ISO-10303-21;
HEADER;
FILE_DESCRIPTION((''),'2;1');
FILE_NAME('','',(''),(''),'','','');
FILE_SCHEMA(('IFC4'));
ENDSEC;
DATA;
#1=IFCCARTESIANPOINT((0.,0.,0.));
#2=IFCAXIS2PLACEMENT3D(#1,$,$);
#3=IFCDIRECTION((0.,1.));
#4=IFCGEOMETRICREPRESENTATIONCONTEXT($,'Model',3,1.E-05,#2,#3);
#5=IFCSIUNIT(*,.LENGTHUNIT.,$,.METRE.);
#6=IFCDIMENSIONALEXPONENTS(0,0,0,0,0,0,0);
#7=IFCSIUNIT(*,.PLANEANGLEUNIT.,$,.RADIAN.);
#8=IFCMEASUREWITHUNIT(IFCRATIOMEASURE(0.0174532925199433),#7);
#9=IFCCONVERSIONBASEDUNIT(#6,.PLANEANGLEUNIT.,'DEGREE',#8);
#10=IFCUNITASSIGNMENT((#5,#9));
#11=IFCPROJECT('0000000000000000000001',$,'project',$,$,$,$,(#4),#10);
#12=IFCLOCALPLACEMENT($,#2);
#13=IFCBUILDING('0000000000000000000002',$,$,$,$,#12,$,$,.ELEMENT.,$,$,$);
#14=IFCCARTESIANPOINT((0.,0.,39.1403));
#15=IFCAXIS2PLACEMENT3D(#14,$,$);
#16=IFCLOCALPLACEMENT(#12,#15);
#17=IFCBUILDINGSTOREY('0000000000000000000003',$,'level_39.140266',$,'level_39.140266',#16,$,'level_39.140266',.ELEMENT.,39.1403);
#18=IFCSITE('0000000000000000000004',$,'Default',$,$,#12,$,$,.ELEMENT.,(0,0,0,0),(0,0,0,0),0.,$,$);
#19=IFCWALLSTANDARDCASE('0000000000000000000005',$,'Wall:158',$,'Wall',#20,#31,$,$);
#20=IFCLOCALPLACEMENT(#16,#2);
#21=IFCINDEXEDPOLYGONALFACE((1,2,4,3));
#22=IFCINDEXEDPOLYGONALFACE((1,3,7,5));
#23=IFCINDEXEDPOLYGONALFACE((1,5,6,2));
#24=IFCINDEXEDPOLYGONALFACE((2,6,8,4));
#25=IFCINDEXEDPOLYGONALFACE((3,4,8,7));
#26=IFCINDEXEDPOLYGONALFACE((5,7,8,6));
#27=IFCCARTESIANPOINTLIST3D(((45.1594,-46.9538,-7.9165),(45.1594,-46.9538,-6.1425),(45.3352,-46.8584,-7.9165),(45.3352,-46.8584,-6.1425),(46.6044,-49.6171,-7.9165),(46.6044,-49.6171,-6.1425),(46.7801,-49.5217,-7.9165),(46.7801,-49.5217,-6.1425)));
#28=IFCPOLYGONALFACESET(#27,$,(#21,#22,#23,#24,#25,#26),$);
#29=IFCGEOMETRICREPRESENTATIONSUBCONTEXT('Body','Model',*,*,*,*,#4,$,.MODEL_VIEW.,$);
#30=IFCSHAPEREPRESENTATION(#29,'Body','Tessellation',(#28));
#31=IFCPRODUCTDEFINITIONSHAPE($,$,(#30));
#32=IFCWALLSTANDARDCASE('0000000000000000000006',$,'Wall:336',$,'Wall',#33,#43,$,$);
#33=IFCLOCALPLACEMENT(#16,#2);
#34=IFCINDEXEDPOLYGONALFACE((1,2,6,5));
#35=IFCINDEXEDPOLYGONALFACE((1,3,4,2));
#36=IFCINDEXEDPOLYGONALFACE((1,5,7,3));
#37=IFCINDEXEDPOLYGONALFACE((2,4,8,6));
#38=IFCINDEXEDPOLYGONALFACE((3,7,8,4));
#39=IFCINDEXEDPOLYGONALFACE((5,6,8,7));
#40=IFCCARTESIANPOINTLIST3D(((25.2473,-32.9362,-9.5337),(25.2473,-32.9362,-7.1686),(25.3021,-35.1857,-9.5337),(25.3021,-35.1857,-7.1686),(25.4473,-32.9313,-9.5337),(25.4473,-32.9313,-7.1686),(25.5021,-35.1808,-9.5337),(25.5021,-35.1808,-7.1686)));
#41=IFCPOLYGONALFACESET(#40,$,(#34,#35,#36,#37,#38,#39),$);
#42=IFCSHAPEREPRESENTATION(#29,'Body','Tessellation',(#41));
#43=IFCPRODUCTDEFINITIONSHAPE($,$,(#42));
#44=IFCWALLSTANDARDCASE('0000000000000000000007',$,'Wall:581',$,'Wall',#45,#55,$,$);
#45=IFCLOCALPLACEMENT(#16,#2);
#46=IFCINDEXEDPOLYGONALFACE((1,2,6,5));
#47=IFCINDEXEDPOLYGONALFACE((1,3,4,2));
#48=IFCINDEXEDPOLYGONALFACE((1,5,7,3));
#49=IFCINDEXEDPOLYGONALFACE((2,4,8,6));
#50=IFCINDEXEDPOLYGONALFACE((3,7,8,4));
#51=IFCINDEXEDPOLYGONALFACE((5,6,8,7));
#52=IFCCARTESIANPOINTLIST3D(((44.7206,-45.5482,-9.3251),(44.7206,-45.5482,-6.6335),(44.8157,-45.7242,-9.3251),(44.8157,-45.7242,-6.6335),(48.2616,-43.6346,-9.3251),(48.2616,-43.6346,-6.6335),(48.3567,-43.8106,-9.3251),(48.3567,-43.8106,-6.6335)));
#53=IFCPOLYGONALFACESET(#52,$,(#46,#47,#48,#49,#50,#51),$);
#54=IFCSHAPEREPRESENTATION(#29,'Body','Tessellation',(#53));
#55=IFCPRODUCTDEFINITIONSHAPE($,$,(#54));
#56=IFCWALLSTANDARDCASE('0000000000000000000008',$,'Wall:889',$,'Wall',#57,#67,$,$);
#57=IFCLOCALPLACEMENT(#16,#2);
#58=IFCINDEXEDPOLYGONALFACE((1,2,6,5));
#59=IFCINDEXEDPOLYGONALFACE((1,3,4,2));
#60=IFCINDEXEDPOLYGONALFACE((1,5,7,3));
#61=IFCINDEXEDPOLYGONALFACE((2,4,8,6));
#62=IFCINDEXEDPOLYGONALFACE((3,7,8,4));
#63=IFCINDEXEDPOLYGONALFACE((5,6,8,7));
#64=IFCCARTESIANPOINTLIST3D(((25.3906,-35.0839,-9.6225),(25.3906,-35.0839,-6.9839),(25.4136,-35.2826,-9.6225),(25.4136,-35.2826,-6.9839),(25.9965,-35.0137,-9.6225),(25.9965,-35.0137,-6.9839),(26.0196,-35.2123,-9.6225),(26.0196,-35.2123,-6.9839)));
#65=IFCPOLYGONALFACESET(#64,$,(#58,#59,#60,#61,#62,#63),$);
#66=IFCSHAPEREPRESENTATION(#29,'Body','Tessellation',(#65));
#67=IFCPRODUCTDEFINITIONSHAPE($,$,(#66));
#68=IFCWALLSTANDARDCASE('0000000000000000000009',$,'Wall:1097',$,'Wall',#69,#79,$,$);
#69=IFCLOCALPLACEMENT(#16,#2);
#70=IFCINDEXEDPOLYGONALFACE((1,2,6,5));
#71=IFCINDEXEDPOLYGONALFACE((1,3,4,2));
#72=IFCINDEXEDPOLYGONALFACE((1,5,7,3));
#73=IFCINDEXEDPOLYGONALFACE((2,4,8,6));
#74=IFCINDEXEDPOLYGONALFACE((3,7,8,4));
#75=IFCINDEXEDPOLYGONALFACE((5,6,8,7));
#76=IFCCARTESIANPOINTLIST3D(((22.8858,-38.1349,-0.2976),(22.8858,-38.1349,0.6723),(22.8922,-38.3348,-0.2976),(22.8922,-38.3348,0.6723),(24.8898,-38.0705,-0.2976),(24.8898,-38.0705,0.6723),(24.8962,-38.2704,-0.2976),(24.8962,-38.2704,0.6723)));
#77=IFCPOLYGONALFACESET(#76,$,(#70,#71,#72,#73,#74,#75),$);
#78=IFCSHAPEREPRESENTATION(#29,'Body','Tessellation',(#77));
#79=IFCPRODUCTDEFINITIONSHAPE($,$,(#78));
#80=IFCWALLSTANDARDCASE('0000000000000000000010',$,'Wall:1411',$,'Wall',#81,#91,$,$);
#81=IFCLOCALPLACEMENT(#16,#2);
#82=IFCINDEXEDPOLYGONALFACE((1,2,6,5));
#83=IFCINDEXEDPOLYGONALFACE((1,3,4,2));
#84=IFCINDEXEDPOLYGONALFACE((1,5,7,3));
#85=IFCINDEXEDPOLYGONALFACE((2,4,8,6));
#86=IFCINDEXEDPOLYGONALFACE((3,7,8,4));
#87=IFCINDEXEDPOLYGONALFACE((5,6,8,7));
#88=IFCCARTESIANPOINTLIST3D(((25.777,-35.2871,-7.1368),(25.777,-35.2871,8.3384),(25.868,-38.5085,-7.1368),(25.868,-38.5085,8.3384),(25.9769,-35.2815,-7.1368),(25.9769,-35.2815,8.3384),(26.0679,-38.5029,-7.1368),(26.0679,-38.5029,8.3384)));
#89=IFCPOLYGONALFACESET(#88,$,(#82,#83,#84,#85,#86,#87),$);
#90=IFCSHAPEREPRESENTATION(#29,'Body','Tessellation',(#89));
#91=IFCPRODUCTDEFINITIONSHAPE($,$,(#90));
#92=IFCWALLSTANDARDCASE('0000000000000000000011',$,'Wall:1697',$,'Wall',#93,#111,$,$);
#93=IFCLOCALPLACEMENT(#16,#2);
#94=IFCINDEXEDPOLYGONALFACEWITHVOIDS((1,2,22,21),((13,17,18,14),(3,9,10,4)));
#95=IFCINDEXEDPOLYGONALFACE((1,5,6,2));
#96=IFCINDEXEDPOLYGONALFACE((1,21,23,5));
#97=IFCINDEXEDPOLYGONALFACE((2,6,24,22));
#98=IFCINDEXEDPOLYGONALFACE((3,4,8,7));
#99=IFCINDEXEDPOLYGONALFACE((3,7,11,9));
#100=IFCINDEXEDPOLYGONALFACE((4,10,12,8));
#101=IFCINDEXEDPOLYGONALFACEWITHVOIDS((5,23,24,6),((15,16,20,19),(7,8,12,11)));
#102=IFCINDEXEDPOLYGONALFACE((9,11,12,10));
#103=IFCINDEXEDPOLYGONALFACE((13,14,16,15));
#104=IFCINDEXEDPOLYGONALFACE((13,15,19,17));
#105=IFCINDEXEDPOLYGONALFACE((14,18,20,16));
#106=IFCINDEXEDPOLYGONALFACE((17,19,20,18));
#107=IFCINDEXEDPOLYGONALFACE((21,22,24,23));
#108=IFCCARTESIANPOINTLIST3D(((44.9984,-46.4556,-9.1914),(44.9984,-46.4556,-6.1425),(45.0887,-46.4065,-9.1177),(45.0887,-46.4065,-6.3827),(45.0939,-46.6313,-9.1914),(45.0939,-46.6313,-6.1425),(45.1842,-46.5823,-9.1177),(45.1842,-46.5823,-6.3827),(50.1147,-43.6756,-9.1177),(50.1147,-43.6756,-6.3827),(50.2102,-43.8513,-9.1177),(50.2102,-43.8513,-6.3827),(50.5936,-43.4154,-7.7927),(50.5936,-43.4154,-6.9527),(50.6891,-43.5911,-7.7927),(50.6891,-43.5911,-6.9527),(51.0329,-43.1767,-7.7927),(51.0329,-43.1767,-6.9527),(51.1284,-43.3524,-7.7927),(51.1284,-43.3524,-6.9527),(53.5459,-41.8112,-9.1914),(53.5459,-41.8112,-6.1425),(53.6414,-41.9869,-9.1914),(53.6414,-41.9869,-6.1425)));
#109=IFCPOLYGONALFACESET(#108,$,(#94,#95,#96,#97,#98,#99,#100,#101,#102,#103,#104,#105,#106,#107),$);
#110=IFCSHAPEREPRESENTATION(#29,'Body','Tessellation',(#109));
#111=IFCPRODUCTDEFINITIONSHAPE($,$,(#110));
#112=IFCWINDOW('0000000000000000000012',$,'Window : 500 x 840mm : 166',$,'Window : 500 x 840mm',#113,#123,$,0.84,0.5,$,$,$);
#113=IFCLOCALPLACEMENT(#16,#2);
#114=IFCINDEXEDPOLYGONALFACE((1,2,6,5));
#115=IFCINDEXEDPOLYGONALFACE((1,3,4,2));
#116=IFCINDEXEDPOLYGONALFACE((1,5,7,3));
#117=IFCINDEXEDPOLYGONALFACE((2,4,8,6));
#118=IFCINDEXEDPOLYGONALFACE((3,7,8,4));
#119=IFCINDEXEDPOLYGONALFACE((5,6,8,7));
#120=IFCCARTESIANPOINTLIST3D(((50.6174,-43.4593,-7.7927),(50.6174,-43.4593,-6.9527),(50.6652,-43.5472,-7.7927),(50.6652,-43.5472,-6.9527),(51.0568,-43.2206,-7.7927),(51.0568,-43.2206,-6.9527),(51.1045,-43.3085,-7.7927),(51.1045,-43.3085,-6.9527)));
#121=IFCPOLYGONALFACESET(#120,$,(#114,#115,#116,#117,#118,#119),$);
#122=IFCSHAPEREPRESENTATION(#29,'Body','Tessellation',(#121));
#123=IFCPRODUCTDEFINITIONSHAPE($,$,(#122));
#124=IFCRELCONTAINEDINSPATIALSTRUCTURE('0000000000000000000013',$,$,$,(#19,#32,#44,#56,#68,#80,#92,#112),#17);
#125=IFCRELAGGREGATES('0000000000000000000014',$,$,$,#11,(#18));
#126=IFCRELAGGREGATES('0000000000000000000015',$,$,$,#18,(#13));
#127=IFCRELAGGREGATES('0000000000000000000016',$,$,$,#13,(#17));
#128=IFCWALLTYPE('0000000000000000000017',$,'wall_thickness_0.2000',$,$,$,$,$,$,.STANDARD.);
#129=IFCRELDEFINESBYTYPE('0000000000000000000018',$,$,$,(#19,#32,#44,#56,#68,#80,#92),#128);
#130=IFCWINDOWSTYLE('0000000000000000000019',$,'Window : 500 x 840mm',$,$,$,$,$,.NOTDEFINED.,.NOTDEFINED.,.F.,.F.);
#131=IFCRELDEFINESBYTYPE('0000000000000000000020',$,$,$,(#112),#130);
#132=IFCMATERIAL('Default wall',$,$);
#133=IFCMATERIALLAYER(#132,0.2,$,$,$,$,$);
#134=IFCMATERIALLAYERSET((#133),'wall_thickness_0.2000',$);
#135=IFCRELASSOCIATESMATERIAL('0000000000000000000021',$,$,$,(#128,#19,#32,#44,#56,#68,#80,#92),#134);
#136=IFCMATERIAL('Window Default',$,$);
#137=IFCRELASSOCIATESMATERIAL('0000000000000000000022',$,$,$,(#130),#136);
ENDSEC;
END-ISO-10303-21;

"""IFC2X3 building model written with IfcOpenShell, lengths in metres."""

from ifc_helpers import new_model, entity, si_unit, converted_unit, direction, frame, frame_2d, origin, origin_2d_with_axis, place, context, subcontext, project, spatial, polyline, rectangle, outline, extrude, source, transform, mapped, material, layer, layer_set, layer_usage, type_object, type_shapes, element, fill, save


model = new_model("IFC2X3")

# Units and contexts
model_context = context("Model", 3, precision=1e-05, world=origin(), true_north=direction((0.0, 1.0)))
body_context = subcontext(model_context, "Body", "Model", "MODEL_VIEW")
ifc_project = project(units=[si_unit("LENGTHUNIT", "METRE"), converted_unit("PLANEANGLEUNIT", "DEGREE", entity("IfcRatioMeasure", 0.0174532925199433), si_unit("PLANEANGLEUNIT", "RADIAN"), dimensions=[0, 0, 0, 0, 0, 0, 0])], contexts=[model_context])

# Site, building, storey
placement_1 = place(None, origin())
site = spatial("IfcSite", under=ifc_project, at=placement_1, Name="Default", CompositionType="ELEMENT", RefLatitude=(0, 0, 0, 0), RefLongitude=(0, 0, 0, 0), RefElevation=0.0)
building = spatial("IfcBuilding", under=site, at=placement_1, CompositionType="ELEMENT")
storey_placement = place(placement_1, frame((0.0, 0.0, 39.1403)))
storey = spatial("IfcBuildingStorey", under=building, at=storey_placement, Name="level_39.140266", ObjectType="level_39.140266", LongName="level_39.140266", CompositionType="ELEMENT", Elevation=39.1403)

# Walls
ifc_material_1 = material(Name="Default wall")
ifc_layer = layer(ifc_material_1, 0.2)
ifc_layer_set = layer_set([ifc_layer], Name="wall_thickness_0.2000")
ifc_layer_usage = layer_usage(ifc_layer_set, "AXIS2", "POSITIVE", -0.1)
wall_type = type_object("IfcWallType", Name="wall_thickness_0.2000", PredefinedType="STANDARD", material=ifc_layer_set)
placement_2 = place(placement_1, frame((0.0, 0.0, 31.2238)))
wall_1_placement = place(placement_2, frame((45.2473, -46.9061, 0.0), z_axis=(0.0, 0.0, 1.0), x_axis=(0.476867, -0.878975, 0.0)))
element("IfcWallStandardCase", 1, at=wall_1_placement, inside=storey, type_object=wall_type, material=ifc_layer_usage, Name="Wall:158", ObjectType="Wall", context=body_context, shape_type="SweptSolid", body=[
    extrude(outline(polyline([(3.03, -0.1), (3.03, 0.1), (0.0, 0.1), (0.0, -0.1), (3.03, -0.1)])), origin(), (0.0, 0.0, 1.0), 1.7741),
])
placement_3 = place(placement_1, frame((0.0, 0.0, 29.6066)))
wall_2_placement = place(placement_3, frame((25.3473, -32.9337, 0.0), z_axis=(0.0, 0.0, 1.0), x_axis=(0.024361, -0.999703, 0.0)))
element("IfcWallStandardCase", 2, at=wall_2_placement, inside=storey, type_object=wall_type, material=ifc_layer_usage, Name="Wall:336", ObjectType="Wall", context=body_context, shape_type="SweptSolid", body=[
    extrude(outline(polyline([(2.2502, -0.1), (2.2502, 0.1), (0.0, 0.1), (0.0, -0.1), (2.2502, -0.1)])), origin(), (0.0, 0.0, 1.0), 2.3651),
])
placement_4 = place(placement_1, frame((0.0, 0.0, 29.8152)))
wall_3_placement = place(placement_4, frame((44.7681, -45.6362, 0.0), z_axis=(0.0, 0.0, 1.0), x_axis=(0.879755, 0.475427, 0.0)))
element("IfcWallStandardCase", 3, at=wall_3_placement, inside=storey, type_object=wall_type, material=ifc_layer_usage, Name="Wall:581", ObjectType="Wall", context=body_context, shape_type="SweptSolid", body=[
    extrude(outline(polyline([(4.025, -0.1), (4.025, 0.1), (0.0, 0.1), (0.0, -0.1), (4.025, -0.1)])), origin(), (0.0, 0.0, 1.0), 2.6916),
])
placement_5 = place(placement_1, frame((0.0, 0.0, 29.5178)))
wall_4_placement = place(placement_5, frame((26.0081, -35.113, 0.0), z_axis=(0.0, 0.0, 1.0), x_axis=(-0.993349, -0.11514, 0.0)))
element("IfcWallStandardCase", 4, at=wall_4_placement, inside=storey, type_object=wall_type, material=ifc_layer_usage, Name="Wall:889", ObjectType="Wall", context=body_context, shape_type="SweptSolid", body=[
    extrude(outline(polyline([(0.61, -0.1), (0.61, 0.1), (0.0, 0.1), (0.0, -0.1), (0.61, -0.1)])), origin(), (0.0, 0.0, 1.0), 2.6386),
])
placement_6 = place(placement_1, frame((0.0, 0.0, 38.8427)))
wall_5_placement = place(placement_6, frame((22.889, -38.2349, 0.0), z_axis=(0.0, 0.0, 1.0), x_axis=(0.999485, 0.032099, 0.0)))
element("IfcWallStandardCase", 5, at=wall_5_placement, inside=storey, type_object=wall_type, material=ifc_layer_usage, Name="Wall:1097", ObjectType="Wall", context=body_context, shape_type="SweptSolid", body=[
    extrude(outline(polyline([(2.005, -0.1), (2.005, 0.1), (0.0, 0.1), (0.0, -0.1), (2.005, -0.1)])), origin(), (0.0, 0.0, 1.0), 0.9699),
])
placement_7 = place(placement_1, frame((0.0, 0.0, 32.0035)))
wall_6_placement = place(placement_7, frame((25.877, -35.2843, 0.0), z_axis=(0.0, 0.0, 1.0), x_axis=(0.028229, -0.999601, 0.0)))
element("IfcWallStandardCase", 6, at=wall_6_placement, inside=storey, type_object=wall_type, material=ifc_layer_usage, Name="Wall:1411", ObjectType="Wall", context=body_context, shape_type="SweptSolid", body=[
    extrude(outline(polyline([(3.2227, -0.1), (3.2227, 0.1), (0.0, 0.1), (0.0, -0.1), (3.2227, -0.1)])), origin(), (0.0, 0.0, 1.0), 15.4752),
])

# Shared definitions
ifc_material_2 = material(Name="Window Default")

# Wall, openings, window
placement_8 = place(placement_1, frame((0.0, 0.0, 29.9489)))
wall_7_placement = place(placement_8, frame((45.0461, -46.5435, 0.0), z_axis=(0.0, 0.0, 1.0), x_axis=(0.878667, 0.477435, 0.0)))
wall_7 = element("IfcWallStandardCase", 7, at=wall_7_placement, inside=storey, type_object=wall_type, material=ifc_layer_usage, Name="Wall:1697", ObjectType="Wall", context=body_context, shape_type="SweptSolid", body=[
    extrude(outline(polyline([(9.7278, -0.1), (9.7278, 0.1), (0.0, 0.1), (0.0, -0.1), (9.7278, -0.1)])), origin(), (0.0, 0.0, 1.0), 3.0489),
])
opening_1_placement = place(wall_7_placement, frame((0.1028, -0.1, 0.0737)))
element("IfcOpeningElement", 8, at=opening_1_placement, cuts=wall_7, ObjectType="Opening", context=body_context, shape_type="SweptSolid", body=[
    extrude(rectangle(XDim=5.72, YDim=2.735, at=frame_2d((1.3675, 2.86), x_axis=(0.0, 1.0))), frame((0.0, 0.0, 0.0), z_axis=(0.0, 1.0, 0.0), x_axis=(0.0, 0.0, 1.0)), (0.0, 0.0, 1.0), 0.2),
])
opening_2_placement = place(wall_7_placement, frame((6.3678, -0.1, 1.3987)))
opening_2 = element("IfcOpeningElement", 9, at=opening_2_placement, cuts=wall_7, ObjectType="Opening", context=body_context, shape_type="SweptSolid", body=[
    extrude(rectangle(XDim=0.5, YDim=0.84, at=frame_2d((0.42, 0.25), x_axis=(0.0, 1.0))), frame((0.0, 0.0, 0.0), z_axis=(0.0, 1.0, 0.0), x_axis=(0.0, 0.0, 1.0)), (0.0, 0.0, 1.0), 0.2),
])
window_style_1 = type_object("IfcWindowStyle", Name="Window : 500 x 840mm", ConstructionType="NOTDEFINED", OperationType="NOTDEFINED", ParameterTakesPrecedence=False, Sizeable=False, material=ifc_material_2)
shared_shape_1 = source(origin(), body_context, "Body", "SweptSolid", [
    extrude(rectangle(XDim=0.1, YDim=0.5, at=origin_2d_with_axis()), frame((0.25, 0.1, 0.0), z_axis=(0.0, 0.0, 1.0), x_axis=(0.0, 1.0, 0.0)), (0.0, 0.0, 1.0), 0.84),
])
type_shapes(window_style_1, [shared_shape_1])
window_1_placement = place(opening_2_placement, origin())
window_1 = element("IfcWindow", 10, at=window_1_placement, inside=storey, type_object=window_style_1, Name="Window : 500 x 840mm : 166", ObjectType="Window : 500 x 840mm", OverallHeight=0.84, OverallWidth=0.5, context=body_context, shape_type="MappedRepresentation", body=[
    mapped(shared_shape_1, transform((0.0, 0.0, 0.0), scale=1.0)),
])
fill(opening_2, window_1)

save(model, "model.ifc")
